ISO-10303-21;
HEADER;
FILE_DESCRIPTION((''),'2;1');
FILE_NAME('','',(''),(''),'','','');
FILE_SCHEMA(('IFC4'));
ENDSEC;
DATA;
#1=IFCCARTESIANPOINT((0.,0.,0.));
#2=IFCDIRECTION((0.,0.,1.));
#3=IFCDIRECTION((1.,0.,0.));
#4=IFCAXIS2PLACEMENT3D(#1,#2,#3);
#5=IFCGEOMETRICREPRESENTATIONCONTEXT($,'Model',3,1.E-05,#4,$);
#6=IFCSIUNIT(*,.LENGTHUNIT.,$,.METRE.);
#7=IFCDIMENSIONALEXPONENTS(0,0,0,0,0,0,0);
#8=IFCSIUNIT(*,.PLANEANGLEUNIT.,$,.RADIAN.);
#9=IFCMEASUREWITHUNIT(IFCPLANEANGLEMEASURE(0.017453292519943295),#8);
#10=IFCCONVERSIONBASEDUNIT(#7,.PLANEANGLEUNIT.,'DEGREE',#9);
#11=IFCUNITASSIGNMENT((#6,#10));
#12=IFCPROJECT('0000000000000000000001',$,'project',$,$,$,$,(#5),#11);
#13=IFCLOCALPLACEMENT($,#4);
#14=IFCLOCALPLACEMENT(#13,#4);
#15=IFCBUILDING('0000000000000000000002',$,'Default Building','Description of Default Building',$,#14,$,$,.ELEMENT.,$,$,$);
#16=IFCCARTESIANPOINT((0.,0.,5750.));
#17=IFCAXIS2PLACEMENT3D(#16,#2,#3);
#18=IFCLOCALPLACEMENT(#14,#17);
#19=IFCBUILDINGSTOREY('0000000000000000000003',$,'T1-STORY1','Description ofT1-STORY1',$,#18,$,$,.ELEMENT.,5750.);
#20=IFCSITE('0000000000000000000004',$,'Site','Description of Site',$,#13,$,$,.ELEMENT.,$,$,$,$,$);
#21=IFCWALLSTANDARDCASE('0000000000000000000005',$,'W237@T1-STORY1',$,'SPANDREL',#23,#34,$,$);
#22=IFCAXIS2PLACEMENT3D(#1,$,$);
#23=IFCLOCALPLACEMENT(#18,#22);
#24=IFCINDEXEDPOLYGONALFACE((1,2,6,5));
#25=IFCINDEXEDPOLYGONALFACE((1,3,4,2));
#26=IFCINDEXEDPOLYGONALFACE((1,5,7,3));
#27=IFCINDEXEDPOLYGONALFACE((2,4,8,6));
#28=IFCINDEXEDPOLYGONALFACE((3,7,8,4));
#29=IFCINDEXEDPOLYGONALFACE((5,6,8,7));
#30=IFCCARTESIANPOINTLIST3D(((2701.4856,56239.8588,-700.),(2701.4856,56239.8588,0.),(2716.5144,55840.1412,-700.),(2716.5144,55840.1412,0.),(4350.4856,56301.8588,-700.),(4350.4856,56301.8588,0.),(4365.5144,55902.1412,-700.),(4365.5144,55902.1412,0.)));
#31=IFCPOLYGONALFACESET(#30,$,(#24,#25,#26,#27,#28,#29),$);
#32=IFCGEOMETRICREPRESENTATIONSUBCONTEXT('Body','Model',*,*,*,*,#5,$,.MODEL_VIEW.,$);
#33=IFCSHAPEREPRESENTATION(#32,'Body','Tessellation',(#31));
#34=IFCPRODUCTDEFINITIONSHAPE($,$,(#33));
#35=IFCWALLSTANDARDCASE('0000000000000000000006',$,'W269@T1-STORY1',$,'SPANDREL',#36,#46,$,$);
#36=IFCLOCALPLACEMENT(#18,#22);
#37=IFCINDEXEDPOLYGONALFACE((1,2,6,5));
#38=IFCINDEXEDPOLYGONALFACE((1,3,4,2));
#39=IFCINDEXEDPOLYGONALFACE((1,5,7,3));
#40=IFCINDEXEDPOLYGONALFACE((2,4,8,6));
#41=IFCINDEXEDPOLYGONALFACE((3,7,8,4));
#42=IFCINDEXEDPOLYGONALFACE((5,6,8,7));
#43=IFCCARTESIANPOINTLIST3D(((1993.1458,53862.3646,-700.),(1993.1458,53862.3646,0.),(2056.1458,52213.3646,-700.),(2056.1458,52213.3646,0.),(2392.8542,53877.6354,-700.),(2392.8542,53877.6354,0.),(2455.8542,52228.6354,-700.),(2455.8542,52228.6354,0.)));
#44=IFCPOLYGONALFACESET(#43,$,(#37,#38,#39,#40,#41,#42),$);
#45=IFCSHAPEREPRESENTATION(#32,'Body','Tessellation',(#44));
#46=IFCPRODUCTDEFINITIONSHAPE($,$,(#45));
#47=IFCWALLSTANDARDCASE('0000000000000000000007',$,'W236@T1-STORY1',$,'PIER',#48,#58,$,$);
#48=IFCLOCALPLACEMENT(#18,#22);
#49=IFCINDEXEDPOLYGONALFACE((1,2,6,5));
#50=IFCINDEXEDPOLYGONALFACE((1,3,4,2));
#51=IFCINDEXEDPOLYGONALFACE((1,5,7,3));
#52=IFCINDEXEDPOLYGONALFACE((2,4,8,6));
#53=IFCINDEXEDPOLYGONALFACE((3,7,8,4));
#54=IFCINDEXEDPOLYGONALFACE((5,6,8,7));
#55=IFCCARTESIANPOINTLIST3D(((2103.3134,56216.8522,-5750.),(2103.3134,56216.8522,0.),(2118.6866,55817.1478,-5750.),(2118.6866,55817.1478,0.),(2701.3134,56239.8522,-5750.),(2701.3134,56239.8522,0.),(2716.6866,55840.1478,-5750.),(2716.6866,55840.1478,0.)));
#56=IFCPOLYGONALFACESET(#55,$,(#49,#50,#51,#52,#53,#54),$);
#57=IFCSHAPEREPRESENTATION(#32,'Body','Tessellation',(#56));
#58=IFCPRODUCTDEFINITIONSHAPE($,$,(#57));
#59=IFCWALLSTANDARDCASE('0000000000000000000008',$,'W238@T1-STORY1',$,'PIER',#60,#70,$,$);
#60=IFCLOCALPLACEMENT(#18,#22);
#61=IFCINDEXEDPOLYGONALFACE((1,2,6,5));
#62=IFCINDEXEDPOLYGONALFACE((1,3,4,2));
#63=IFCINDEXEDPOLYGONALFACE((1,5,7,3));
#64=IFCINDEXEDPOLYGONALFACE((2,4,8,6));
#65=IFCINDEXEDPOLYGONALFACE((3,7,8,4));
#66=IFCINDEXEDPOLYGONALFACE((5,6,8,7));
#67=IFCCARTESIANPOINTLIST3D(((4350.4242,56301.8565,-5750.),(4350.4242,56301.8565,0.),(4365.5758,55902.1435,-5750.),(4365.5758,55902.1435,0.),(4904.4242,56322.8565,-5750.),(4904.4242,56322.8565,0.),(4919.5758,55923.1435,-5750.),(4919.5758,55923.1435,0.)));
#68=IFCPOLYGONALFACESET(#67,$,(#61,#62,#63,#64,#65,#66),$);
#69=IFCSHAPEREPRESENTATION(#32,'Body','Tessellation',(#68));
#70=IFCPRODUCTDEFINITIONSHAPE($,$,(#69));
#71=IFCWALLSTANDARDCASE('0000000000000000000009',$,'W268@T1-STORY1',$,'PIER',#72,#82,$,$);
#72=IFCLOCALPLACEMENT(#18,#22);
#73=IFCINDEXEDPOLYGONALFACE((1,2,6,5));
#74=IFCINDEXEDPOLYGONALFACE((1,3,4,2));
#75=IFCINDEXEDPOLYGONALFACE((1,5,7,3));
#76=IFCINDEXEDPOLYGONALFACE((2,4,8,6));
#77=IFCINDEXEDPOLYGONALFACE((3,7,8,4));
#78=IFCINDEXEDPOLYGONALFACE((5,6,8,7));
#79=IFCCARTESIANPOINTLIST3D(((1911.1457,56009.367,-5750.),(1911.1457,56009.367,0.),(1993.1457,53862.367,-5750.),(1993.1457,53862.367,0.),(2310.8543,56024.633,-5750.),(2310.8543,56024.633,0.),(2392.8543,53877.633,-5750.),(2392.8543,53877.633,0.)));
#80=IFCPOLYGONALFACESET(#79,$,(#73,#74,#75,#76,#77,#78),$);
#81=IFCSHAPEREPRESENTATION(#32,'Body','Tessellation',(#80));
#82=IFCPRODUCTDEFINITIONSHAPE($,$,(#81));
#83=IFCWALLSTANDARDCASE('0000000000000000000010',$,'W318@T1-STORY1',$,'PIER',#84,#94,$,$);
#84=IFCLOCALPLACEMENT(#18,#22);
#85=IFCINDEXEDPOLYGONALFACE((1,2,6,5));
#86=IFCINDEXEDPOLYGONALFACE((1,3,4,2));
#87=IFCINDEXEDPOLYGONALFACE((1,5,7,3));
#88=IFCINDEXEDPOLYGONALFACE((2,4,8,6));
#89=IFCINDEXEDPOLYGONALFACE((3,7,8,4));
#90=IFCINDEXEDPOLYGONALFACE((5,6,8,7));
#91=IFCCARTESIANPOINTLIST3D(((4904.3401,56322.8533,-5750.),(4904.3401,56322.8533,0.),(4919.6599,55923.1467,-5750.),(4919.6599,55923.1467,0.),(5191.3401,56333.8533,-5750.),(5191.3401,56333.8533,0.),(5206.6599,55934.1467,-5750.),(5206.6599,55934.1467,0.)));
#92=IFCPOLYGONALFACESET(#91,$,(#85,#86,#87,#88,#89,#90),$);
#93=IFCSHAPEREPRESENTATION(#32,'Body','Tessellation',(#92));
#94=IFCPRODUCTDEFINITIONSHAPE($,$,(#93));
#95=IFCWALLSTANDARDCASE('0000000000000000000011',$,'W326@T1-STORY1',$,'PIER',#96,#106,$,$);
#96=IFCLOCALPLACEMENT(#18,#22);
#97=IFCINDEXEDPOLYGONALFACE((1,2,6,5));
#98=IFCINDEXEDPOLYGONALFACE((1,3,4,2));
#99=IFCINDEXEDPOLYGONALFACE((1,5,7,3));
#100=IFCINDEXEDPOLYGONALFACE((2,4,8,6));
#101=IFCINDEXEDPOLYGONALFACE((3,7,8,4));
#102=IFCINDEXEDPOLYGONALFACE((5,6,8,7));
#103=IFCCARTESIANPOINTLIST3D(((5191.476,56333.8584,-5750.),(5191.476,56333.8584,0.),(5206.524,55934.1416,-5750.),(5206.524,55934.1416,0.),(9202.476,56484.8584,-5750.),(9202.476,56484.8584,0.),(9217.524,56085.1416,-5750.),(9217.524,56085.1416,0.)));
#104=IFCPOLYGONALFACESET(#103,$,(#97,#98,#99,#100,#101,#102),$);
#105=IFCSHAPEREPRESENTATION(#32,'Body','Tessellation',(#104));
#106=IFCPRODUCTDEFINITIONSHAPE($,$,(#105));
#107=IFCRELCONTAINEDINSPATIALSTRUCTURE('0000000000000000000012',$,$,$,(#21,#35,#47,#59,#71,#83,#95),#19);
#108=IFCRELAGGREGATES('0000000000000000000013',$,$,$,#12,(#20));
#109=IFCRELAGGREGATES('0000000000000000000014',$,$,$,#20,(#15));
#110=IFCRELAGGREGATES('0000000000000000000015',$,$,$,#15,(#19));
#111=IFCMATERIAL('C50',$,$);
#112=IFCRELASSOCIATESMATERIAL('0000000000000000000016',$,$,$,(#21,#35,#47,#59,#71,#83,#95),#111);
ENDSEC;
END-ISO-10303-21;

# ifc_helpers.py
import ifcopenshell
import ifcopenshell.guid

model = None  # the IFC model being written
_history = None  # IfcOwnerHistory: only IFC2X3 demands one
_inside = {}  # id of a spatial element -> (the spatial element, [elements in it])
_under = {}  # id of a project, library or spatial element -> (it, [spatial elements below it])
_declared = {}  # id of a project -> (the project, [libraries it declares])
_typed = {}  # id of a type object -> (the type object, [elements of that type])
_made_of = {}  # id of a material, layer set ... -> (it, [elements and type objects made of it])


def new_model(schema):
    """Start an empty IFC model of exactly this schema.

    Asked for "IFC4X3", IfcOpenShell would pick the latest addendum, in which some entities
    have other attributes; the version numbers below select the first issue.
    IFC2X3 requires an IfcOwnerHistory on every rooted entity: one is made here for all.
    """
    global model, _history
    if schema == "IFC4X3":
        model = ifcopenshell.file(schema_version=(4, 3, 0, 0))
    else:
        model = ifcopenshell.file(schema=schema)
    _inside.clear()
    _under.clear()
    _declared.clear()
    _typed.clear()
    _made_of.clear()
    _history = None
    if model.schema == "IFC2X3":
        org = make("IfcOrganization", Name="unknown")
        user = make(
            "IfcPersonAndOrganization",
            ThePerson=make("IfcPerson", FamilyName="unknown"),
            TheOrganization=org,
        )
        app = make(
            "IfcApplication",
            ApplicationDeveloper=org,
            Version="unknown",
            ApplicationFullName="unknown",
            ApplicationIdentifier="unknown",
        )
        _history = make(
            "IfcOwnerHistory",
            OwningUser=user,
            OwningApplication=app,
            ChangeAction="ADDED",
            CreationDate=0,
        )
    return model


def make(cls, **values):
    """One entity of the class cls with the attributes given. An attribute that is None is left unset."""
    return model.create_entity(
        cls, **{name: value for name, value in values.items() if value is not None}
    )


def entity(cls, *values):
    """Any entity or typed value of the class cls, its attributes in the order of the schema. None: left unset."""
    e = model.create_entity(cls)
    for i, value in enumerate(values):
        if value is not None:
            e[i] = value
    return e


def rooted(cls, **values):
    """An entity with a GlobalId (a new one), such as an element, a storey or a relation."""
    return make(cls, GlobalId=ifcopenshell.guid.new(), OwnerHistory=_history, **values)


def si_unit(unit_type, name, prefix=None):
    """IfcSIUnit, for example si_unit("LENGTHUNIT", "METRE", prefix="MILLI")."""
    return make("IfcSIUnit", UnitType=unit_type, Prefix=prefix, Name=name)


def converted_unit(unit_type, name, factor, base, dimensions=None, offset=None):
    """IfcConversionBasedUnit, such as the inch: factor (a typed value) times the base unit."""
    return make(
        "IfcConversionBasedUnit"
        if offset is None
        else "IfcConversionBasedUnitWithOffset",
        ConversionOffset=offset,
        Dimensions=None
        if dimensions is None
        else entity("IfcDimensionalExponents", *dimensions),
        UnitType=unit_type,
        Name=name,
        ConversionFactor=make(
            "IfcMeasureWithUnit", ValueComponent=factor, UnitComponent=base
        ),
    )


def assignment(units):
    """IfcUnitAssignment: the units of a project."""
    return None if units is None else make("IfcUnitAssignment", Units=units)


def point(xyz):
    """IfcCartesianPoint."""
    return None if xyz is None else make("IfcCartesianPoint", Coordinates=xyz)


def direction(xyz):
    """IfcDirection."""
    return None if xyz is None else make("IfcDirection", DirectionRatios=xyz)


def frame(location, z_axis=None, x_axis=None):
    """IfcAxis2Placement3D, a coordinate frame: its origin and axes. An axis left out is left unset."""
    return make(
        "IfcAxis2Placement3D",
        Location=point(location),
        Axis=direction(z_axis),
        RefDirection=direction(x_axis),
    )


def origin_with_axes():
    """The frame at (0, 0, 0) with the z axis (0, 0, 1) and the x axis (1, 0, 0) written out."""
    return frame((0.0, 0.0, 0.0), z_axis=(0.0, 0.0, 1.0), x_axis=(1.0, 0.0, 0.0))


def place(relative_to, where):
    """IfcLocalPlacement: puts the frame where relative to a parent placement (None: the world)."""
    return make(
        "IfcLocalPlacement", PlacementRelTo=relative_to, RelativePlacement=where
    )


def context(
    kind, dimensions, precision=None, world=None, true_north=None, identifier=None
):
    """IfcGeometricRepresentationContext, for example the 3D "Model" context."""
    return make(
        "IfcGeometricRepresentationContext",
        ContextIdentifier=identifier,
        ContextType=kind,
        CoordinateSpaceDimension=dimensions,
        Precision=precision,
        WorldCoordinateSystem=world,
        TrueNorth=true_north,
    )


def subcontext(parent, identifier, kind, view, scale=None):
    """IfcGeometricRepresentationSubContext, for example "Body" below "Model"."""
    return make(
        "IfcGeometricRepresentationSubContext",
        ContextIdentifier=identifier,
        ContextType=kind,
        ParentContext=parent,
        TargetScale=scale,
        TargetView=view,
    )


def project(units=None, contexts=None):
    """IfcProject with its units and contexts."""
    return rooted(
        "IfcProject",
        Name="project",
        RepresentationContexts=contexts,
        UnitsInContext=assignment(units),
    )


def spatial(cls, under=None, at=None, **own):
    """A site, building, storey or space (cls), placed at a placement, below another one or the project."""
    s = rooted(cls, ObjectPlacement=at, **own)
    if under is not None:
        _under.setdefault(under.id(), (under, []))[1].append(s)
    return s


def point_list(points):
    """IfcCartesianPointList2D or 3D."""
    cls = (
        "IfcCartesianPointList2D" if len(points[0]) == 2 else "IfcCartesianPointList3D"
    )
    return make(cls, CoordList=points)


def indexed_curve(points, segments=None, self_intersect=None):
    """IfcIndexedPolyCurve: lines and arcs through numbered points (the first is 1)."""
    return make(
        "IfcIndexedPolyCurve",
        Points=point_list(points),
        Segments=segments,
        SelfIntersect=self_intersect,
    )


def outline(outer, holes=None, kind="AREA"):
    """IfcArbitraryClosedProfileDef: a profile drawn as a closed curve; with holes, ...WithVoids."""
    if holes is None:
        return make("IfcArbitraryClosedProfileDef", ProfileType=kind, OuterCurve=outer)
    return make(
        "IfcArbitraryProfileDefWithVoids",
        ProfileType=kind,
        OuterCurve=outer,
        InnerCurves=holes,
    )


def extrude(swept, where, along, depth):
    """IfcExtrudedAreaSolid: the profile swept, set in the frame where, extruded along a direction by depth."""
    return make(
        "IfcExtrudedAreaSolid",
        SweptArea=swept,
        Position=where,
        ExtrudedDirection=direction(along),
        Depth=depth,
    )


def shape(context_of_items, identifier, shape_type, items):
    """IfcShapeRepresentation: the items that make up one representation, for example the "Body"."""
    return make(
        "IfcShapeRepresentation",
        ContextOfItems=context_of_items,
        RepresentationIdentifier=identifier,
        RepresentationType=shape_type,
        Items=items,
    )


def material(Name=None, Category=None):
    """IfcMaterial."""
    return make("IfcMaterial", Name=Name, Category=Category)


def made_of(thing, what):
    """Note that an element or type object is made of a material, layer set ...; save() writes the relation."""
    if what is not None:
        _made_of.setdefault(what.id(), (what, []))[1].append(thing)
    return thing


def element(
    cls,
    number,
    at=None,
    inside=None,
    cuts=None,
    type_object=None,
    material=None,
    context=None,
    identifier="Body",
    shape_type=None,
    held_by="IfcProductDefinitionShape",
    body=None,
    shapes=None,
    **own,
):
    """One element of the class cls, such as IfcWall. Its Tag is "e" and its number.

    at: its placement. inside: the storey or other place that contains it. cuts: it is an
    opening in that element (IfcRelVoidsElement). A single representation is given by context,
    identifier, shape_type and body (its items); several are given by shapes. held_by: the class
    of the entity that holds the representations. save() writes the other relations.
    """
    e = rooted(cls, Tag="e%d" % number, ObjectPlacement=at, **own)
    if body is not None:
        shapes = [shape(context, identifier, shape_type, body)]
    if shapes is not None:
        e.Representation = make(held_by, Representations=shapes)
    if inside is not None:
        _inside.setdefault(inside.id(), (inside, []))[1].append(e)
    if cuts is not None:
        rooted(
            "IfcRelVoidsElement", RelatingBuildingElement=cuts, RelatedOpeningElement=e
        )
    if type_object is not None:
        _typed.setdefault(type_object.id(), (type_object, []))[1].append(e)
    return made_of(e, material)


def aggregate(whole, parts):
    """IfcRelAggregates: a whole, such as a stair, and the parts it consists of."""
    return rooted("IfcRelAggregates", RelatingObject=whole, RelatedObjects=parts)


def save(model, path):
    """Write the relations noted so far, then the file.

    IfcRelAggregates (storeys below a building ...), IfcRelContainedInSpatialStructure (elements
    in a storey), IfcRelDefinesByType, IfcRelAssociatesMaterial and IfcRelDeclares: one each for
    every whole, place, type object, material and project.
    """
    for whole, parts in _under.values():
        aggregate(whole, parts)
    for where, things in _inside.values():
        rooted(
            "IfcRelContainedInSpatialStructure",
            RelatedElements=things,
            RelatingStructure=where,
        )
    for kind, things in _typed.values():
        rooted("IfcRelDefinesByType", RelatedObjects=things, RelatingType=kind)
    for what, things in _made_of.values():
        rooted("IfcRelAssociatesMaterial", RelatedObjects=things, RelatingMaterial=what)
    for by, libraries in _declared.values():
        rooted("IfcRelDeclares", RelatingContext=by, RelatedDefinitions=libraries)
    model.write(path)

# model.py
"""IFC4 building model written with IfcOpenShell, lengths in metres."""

from ifc_helpers import new_model, entity, si_unit, converted_unit, frame, origin_with_axes, place, context, subcontext, project, spatial, indexed_curve, outline, extrude, material, element, save


model = new_model("IFC4")

# Units and contexts
model_context = context("Model", 3, precision=1e-05, world=origin_with_axes())
body_context = subcontext(model_context, "Body", "Model", "MODEL_VIEW")
ifc_project = project(units=[si_unit("LENGTHUNIT", "METRE"), converted_unit("PLANEANGLEUNIT", "DEGREE", entity("IfcPlaneAngleMeasure", 0.017453292519943295), si_unit("PLANEANGLEUNIT", "RADIAN"), dimensions=[0, 0, 0, 0, 0, 0, 0])], contexts=[model_context])

# Site, building, storey
site_placement = place(None, origin_with_axes())
site = spatial("IfcSite", under=ifc_project, at=site_placement, Name="Site", Description="Description of Site", CompositionType="ELEMENT")
building_placement = place(site_placement, origin_with_axes())
building = spatial("IfcBuilding", under=site, at=building_placement, Name="Default Building", Description="Description of Default Building", CompositionType="ELEMENT")
storey_placement = place(building_placement, frame((0.0, 0.0, 5750.0), z_axis=(0.0, 0.0, 1.0), x_axis=(1.0, 0.0, 0.0)))
storey = spatial("IfcBuildingStorey", under=building, at=storey_placement, Name="T1-STORY1", Description="Description ofT1-STORY1", CompositionType="ELEMENT", Elevation=5750.0)

# Shared definitions
ifc_material_1 = material(Name="C50")

# Walls
wall_1_placement = place(storey_placement, frame((2709.0, 56040.0, -700.0), z_axis=(0.0, 0.0, 1.0), x_axis=(0.999294, 0.037572, 0.0)))
element("IfcWallStandardCase", 1, at=wall_1_placement, inside=storey, material=ifc_material_1, Name="W237@T1-STORY1", ObjectType="SPANDREL", context=body_context, shape_type="SweptSolid", body=[
    extrude(outline(indexed_curve([(0.0, -200.0), (0.0, 200.0), (1650.1651, 200.0), (1650.1651, -200.0), (0.0, -200.0)], self_intersect=False)), origin_with_axes(), (0.0, 0.0, 1.0), 700.0),
])
wall_2_placement = place(storey_placement, frame((2193.0, 53870.0, -700.0), z_axis=(0.0, 0.0, 1.0), x_axis=(0.038177, -0.999271, 0.0)))
element("IfcWallStandardCase", 2, at=wall_2_placement, inside=storey, material=ifc_material_1, Name="W269@T1-STORY1", ObjectType="SPANDREL", context=body_context, shape_type="SweptSolid", body=[
    extrude(outline(indexed_curve([(0.0, -200.0), (0.0, 200.0), (1650.203, 200.0), (1650.203, -200.0), (0.0, -200.0)], self_intersect=False)), origin_with_axes(), (0.0, 0.0, 1.0), 700.0),
])
wall_3_placement = place(storey_placement, frame((2111.0, 56017.0, -5750.0), z_axis=(0.0, 0.0, 1.0), x_axis=(0.999261, 0.038433, 0.0)))
element("IfcWallStandardCase", 3, at=wall_3_placement, inside=storey, material=ifc_material_1, Name="W236@T1-STORY1", ObjectType="PIER", context=body_context, shape_type="SweptSolid", body=[
    extrude(outline(indexed_curve([(0.0, -200.0), (0.0, 200.0), (598.4421, 200.0), (598.4421, -200.0), (0.0, -200.0)], self_intersect=False)), origin_with_axes(), (0.0, 0.0, 1.0), 5750.0),
])
wall_4_placement = place(storey_placement, frame((4358.0, 56102.0, -5750.0), z_axis=(0.0, 0.0, 1.0), x_axis=(0.999282, 0.037879, 0.0)))
element("IfcWallStandardCase", 4, at=wall_4_placement, inside=storey, material=ifc_material_1, Name="W238@T1-STORY1", ObjectType="PIER", context=body_context, shape_type="SweptSolid", body=[
    extrude(outline(indexed_curve([(0.0, -200.0), (0.0, 200.0), (554.3979, 200.0), (554.3979, -200.0), (0.0, -200.0)], self_intersect=False)), origin_with_axes(), (0.0, 0.0, 1.0), 5750.0),
])
wall_5_placement = place(storey_placement, frame((2111.0, 56017.0, -5750.0), z_axis=(0.0, 0.0, 1.0), x_axis=(0.038165, -0.999271, 0.0)))
element("IfcWallStandardCase", 5, at=wall_5_placement, inside=storey, material=ifc_material_1, Name="W268@T1-STORY1", ObjectType="PIER", context=body_context, shape_type="SweptSolid", body=[
    extrude(outline(indexed_curve([(0.0, -200.0), (0.0, 200.0), (2148.5653, 200.0), (2148.5653, -200.0), (0.0, -200.0)], self_intersect=False)), origin_with_axes(), (0.0, 0.0, 1.0), 5750.0),
])
wall_6_placement = place(storey_placement, frame((4912.0, 56123.0, -5750.0), z_axis=(0.0, 0.0, 1.0), x_axis=(0.999266, 0.038299, 0.0)))
element("IfcWallStandardCase", 6, at=wall_6_placement, inside=storey, material=ifc_material_1, Name="W318@T1-STORY1", ObjectType="PIER", context=body_context, shape_type="SweptSolid", body=[
    extrude(outline(indexed_curve([(0.0, -200.0), (0.0, 200.0), (287.2107, 200.0), (287.2107, -200.0), (0.0, -200.0)], self_intersect=False)), origin_with_axes(), (0.0, 0.0, 1.0), 5750.0),
])
wall_7_placement = place(storey_placement, frame((5199.0, 56134.0, -5750.0), z_axis=(0.0, 0.0, 1.0), x_axis=(0.999292, 0.03762, 0.0)))
element("IfcWallStandardCase", 7, at=wall_7_placement, inside=storey, material=ifc_material_1, Name="W326@T1-STORY1", ObjectType="PIER", context=body_context, shape_type="SweptSolid", body=[
    extrude(outline(indexed_curve([(0.0, -200.0), (0.0, 200.0), (4013.8413, 200.0), (4013.8413, -200.0), (0.0, -200.0)], self_intersect=False)), origin_with_axes(), (0.0, 0.0, 1.0), 5750.0),
])

save(model, "model.ifc")
